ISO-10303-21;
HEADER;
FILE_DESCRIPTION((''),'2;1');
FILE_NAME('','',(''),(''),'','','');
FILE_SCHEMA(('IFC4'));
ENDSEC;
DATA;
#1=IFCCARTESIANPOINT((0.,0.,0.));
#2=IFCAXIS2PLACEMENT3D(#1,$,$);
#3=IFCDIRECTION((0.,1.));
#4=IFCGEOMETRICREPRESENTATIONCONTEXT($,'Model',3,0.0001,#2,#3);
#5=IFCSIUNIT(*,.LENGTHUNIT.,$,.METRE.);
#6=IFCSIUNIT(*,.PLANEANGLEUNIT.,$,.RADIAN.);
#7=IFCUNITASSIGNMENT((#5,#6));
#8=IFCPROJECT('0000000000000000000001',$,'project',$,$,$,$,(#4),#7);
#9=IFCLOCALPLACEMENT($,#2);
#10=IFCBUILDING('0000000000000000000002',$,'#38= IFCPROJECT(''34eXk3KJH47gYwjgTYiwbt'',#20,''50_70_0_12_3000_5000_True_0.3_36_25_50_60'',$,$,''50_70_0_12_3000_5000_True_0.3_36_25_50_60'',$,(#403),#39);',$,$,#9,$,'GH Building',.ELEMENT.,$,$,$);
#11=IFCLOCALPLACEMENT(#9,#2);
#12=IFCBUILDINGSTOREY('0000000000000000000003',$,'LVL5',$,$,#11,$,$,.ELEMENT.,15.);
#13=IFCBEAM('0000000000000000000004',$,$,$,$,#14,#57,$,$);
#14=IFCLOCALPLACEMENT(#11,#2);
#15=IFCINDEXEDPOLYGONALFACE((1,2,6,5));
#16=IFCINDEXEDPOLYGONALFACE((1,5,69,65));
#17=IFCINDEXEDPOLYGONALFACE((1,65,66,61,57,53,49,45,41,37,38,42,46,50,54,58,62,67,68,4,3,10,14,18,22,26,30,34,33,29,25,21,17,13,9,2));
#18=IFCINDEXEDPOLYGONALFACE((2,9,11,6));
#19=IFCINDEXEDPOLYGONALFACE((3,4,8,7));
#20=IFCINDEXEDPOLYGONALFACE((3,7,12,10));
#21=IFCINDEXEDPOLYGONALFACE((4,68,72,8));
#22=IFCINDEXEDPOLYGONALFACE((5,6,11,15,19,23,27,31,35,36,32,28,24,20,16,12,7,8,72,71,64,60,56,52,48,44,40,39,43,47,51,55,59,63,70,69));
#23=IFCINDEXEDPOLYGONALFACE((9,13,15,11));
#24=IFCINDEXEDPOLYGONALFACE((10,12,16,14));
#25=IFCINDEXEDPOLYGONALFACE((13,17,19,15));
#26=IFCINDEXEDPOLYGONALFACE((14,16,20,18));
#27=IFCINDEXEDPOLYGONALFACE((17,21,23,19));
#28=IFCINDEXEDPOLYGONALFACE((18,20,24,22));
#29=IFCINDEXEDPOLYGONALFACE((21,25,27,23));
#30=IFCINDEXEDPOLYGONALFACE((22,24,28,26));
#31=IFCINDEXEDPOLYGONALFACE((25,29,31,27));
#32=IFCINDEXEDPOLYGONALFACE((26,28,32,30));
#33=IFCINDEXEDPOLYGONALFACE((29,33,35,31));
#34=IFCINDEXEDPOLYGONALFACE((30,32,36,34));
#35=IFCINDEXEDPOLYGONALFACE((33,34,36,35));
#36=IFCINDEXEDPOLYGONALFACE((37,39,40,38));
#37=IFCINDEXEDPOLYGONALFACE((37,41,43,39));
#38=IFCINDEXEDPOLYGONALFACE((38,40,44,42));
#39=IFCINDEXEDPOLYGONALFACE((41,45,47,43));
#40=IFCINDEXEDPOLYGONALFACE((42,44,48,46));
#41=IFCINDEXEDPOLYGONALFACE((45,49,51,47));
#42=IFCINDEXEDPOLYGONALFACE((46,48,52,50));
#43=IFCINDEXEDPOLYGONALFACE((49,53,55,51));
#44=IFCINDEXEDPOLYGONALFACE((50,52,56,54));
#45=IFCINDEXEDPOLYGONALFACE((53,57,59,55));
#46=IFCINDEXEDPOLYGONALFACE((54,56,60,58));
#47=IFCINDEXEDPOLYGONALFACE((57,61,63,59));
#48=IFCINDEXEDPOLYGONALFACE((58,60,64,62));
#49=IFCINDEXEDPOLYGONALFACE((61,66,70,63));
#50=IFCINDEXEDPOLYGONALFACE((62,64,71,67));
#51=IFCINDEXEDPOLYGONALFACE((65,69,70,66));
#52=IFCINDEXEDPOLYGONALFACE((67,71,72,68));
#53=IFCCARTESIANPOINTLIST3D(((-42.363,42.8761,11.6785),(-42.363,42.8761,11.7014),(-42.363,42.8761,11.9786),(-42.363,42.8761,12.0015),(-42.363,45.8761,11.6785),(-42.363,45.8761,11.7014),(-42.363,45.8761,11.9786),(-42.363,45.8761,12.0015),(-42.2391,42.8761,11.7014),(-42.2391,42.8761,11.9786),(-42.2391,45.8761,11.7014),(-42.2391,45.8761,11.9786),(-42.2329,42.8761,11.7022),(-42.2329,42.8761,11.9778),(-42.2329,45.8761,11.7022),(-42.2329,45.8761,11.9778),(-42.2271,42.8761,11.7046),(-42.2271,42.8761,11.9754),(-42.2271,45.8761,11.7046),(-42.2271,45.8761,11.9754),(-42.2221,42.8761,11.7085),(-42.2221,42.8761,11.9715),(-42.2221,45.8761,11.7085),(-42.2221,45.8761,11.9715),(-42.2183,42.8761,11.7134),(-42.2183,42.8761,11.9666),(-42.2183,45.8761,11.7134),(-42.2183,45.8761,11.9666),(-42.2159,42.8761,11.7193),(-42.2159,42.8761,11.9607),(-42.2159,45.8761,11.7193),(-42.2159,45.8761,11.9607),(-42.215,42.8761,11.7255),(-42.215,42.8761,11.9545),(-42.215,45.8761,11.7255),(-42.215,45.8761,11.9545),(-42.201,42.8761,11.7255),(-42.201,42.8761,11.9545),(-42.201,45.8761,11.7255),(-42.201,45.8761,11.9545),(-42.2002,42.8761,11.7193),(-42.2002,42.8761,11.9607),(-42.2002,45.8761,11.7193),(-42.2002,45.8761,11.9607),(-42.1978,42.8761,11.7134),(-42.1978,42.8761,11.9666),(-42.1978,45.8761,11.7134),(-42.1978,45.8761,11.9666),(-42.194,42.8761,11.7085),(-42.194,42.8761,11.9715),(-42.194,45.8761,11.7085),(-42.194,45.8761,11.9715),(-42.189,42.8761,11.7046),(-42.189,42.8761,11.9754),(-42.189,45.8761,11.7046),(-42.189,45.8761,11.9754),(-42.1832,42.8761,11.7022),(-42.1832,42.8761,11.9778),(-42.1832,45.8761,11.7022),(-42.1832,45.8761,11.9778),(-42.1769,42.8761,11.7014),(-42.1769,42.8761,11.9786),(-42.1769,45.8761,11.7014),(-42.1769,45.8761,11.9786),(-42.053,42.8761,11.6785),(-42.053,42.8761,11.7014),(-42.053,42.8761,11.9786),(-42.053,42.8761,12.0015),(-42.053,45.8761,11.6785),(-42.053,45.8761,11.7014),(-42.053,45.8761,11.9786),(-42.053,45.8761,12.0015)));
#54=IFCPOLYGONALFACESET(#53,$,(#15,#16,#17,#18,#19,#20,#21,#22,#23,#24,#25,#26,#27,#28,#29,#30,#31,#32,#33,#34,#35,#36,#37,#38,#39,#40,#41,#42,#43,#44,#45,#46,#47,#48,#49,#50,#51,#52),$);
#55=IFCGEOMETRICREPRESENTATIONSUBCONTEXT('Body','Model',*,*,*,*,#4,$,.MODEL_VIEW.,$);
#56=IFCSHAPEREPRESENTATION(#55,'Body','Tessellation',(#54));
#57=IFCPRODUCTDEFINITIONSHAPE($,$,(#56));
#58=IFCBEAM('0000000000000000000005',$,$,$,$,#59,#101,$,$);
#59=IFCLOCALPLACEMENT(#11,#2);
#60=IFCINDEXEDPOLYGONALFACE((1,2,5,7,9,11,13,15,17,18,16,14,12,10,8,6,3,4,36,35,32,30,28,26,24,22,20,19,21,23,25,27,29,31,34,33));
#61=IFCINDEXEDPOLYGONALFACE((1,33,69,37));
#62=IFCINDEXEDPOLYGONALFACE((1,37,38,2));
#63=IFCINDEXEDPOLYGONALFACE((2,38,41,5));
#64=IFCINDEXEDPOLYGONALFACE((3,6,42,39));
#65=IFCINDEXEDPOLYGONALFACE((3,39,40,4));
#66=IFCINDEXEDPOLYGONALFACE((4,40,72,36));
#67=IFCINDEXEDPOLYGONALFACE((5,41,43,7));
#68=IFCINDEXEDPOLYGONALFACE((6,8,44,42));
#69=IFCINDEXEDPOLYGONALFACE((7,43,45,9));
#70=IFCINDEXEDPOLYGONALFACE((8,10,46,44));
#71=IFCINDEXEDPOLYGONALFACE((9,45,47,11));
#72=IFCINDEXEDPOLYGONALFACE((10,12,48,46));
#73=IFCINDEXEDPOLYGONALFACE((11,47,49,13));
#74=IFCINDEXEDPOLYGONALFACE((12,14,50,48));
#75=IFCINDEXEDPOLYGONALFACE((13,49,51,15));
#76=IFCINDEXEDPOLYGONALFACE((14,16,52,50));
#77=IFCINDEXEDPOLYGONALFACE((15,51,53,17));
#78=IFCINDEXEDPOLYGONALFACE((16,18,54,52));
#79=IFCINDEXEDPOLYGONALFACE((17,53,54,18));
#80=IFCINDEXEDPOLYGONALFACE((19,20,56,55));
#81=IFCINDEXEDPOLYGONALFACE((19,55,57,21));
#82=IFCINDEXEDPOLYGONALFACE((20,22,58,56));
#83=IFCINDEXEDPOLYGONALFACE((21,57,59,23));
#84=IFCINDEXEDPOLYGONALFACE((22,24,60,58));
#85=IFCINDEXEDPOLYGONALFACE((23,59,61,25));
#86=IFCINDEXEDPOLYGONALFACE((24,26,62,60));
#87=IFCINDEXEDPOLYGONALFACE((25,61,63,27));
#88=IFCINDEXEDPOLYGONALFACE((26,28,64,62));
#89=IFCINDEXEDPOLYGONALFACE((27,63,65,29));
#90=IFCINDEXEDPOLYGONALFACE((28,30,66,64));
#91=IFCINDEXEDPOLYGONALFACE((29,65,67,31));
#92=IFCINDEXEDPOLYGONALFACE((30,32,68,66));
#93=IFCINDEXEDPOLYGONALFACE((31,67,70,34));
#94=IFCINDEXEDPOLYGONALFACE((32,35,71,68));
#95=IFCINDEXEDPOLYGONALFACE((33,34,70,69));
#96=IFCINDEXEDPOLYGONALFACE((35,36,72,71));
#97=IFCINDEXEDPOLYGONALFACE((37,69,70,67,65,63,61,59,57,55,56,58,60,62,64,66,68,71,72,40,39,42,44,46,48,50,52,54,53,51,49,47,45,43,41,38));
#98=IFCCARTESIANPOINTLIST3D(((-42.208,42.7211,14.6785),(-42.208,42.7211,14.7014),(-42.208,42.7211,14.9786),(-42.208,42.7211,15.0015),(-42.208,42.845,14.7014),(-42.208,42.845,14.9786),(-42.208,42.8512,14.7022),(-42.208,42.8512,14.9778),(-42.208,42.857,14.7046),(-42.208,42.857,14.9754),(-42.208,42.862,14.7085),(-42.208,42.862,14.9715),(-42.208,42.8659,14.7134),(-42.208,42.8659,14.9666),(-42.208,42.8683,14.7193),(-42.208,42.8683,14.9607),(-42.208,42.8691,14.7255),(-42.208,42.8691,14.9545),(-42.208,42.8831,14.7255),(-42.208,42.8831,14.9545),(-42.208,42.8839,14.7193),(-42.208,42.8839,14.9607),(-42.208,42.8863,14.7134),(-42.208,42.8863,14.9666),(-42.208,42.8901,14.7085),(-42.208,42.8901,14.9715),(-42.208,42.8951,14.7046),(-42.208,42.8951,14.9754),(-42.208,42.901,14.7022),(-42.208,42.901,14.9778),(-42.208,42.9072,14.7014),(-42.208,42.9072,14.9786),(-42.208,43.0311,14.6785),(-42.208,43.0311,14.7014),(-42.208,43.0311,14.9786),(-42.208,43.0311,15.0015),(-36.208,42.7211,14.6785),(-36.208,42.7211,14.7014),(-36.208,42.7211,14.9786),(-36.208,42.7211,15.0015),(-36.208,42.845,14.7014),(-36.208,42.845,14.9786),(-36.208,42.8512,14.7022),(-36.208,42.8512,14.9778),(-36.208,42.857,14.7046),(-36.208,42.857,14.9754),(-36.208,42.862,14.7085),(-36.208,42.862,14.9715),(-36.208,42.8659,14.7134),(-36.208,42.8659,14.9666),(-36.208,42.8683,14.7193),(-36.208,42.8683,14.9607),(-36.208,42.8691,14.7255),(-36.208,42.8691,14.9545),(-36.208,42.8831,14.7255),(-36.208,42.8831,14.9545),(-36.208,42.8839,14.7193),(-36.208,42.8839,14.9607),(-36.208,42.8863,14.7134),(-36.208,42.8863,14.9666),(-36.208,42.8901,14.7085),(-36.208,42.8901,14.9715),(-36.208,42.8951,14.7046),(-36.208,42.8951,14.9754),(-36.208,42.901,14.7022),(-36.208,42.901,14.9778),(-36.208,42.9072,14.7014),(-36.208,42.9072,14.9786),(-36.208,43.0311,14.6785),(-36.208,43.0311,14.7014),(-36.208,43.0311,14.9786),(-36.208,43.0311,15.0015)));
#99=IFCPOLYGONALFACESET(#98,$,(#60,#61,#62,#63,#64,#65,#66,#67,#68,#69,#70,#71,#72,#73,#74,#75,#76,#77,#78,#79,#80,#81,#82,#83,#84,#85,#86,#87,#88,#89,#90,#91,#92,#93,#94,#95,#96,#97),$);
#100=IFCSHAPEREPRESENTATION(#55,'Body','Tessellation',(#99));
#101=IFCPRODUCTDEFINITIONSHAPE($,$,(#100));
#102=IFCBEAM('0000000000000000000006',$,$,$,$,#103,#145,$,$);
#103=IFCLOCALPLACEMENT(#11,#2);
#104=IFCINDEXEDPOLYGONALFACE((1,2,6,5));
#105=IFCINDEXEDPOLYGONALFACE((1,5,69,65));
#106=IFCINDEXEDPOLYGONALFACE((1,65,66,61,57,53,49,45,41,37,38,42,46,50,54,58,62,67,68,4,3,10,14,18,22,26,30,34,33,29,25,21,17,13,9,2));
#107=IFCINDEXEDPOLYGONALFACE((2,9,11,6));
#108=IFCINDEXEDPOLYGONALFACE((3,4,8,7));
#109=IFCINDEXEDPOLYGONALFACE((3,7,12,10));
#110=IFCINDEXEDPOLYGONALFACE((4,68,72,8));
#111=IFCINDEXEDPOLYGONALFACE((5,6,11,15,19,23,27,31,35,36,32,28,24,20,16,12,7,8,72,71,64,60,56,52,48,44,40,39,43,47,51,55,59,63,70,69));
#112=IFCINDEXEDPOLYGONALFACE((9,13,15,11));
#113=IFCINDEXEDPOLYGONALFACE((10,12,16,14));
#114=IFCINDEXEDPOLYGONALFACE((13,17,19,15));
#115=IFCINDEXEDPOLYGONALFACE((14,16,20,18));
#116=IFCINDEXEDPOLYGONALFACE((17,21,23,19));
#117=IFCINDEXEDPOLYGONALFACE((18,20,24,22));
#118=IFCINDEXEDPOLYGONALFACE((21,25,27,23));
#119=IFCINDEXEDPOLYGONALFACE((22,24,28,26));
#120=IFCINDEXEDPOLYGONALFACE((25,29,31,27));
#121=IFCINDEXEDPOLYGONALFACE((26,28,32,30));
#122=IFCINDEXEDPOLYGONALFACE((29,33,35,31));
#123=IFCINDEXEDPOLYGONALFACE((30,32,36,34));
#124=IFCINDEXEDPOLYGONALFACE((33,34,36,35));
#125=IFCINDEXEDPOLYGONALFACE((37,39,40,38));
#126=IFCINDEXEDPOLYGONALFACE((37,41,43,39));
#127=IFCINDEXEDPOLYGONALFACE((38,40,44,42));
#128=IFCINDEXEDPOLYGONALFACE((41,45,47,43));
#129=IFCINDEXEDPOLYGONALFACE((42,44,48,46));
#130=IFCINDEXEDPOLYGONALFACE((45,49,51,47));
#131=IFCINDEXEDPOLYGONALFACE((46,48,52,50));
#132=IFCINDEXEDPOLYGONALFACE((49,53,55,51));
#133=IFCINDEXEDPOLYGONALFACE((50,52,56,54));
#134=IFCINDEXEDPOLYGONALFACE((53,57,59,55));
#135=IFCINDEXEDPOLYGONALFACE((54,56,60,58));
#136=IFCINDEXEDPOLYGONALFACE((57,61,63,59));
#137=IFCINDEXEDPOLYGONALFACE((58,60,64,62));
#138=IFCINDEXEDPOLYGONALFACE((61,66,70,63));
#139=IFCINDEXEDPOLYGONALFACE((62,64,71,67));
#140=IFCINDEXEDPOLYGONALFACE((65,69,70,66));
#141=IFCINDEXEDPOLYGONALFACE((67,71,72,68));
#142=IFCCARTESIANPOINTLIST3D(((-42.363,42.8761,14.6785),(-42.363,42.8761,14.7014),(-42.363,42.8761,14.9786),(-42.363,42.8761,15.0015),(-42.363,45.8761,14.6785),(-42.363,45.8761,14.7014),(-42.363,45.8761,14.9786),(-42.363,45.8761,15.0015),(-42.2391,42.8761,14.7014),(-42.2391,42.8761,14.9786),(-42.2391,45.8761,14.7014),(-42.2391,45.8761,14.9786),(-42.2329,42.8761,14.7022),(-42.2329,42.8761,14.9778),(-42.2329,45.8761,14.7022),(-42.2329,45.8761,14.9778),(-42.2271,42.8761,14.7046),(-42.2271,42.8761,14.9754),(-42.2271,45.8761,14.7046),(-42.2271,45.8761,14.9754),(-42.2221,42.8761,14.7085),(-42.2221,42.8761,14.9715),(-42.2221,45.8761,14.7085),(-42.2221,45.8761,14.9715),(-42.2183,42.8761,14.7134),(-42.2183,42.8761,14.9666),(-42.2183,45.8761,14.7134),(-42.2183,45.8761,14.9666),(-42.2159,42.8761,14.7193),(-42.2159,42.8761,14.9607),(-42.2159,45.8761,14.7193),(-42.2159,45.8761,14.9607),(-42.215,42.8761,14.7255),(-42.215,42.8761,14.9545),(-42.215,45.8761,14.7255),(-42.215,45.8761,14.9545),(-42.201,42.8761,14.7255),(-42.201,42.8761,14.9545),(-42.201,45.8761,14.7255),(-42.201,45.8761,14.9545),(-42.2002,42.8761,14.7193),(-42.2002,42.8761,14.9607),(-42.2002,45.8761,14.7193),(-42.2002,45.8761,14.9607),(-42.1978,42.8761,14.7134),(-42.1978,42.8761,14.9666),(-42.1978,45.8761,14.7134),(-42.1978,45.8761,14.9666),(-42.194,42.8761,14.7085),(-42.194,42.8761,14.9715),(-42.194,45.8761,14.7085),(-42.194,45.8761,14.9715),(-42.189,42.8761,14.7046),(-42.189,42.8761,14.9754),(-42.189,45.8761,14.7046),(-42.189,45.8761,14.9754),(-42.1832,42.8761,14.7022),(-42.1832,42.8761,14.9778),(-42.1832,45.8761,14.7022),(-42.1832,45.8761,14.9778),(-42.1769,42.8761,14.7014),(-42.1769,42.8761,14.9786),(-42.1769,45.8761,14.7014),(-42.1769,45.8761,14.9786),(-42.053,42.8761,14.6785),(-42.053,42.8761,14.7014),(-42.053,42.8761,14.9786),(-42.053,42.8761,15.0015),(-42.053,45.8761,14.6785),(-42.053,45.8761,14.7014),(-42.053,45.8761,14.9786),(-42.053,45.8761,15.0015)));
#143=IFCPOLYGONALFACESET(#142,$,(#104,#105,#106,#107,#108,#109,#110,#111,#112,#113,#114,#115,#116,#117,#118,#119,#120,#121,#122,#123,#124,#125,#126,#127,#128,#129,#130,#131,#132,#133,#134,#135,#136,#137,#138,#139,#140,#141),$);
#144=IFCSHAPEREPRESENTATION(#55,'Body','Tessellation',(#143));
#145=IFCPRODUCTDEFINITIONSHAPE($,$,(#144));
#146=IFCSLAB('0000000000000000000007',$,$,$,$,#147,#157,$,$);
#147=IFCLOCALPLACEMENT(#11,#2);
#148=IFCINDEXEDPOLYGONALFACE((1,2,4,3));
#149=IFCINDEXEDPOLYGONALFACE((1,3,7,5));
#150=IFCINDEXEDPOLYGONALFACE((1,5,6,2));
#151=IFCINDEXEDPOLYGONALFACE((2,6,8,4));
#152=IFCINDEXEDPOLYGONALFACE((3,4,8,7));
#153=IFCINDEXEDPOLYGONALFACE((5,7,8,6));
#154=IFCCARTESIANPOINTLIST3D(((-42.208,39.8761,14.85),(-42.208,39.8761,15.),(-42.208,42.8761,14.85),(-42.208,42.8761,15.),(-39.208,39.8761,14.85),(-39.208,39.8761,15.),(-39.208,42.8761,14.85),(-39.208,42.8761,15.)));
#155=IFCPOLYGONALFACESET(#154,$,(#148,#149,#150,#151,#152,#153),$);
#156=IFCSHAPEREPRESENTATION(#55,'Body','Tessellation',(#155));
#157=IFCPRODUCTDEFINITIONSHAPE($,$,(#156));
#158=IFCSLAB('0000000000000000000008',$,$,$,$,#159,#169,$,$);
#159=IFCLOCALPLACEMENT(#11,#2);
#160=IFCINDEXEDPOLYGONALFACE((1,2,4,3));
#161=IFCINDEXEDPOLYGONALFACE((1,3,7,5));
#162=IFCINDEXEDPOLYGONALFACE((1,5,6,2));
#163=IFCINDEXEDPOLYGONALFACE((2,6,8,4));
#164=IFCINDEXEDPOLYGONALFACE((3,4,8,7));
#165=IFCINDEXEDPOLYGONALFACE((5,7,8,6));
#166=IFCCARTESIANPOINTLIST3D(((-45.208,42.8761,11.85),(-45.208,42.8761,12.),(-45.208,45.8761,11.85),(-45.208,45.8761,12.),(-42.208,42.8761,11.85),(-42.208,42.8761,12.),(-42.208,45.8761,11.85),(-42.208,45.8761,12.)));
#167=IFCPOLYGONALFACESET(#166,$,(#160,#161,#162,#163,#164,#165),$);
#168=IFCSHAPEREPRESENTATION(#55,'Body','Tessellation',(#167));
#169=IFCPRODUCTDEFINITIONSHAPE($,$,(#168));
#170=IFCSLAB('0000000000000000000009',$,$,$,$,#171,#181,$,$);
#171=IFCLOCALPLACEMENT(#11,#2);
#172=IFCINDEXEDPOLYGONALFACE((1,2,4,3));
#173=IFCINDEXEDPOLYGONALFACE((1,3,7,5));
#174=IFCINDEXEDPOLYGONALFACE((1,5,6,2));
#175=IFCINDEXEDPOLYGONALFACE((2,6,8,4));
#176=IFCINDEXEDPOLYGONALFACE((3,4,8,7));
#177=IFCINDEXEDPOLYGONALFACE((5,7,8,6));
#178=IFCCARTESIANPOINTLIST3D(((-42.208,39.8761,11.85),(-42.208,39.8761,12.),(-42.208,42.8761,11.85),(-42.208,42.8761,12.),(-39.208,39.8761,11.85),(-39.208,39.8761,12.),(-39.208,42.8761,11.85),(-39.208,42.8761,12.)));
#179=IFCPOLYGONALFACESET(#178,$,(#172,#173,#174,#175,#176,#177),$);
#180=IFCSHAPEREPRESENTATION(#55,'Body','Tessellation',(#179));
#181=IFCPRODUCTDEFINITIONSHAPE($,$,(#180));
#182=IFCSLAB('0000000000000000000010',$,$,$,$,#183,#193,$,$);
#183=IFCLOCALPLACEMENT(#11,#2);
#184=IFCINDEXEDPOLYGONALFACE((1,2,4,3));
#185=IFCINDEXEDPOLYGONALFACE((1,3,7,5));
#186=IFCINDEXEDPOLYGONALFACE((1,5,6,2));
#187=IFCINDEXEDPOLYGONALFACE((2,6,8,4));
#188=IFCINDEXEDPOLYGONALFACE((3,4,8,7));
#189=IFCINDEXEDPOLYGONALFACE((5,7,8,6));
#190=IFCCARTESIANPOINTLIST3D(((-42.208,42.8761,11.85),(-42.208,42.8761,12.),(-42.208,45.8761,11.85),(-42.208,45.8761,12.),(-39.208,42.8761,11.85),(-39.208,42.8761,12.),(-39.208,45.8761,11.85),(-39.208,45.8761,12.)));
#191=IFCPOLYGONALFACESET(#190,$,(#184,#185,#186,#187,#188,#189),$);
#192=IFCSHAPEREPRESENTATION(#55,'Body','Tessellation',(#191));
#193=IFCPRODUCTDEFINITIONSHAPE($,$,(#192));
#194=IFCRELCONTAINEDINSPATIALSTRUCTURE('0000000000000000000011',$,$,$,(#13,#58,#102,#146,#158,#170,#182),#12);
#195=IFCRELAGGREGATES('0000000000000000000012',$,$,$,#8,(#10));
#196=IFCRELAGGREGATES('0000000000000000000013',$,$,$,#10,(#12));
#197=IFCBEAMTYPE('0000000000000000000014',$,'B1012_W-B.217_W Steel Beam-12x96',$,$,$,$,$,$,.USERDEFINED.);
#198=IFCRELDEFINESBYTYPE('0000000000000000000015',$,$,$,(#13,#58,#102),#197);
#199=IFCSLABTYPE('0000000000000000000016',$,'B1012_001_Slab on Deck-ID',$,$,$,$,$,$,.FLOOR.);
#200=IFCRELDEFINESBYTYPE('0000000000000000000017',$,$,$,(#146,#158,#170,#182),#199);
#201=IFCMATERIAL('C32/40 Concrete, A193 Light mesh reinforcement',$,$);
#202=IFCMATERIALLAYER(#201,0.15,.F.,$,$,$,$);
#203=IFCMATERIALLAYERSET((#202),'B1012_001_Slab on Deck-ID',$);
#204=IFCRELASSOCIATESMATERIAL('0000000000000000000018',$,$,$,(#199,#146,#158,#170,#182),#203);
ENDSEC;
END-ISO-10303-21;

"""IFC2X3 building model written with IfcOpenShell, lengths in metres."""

from ifc_helpers import new_model, si_unit, direction, frame, origin, origin_2d, place, context, subcontext, project, spatial, polyline, i_section, outline, extrude, material, layer, layer_set, layer_usage, type_object, element, save


model = new_model("IFC2X3")

# Units and contexts
model_context = context("Model", 3, precision=0.0001, world=origin(), true_north=direction((0.0, 1.0)))
body_context = subcontext(model_context, "Body", "Model", "MODEL_VIEW")
ifc_project = project(units=[si_unit("LENGTHUNIT", "METRE"), si_unit("PLANEANGLEUNIT", "RADIAN")], contexts=[model_context])

# Building, storey
building_placement = place(None, origin())
building = spatial("IfcBuilding", under=ifc_project, at=building_placement, Name="#38= IFCPROJECT('34eXk3KJH47gYwjgTYiwbt',#20,'50_70_0_12_3000_5000_True_0.3_36_25_50_60',$,$,'50_70_0_12_3000_5000_True_0.3_36_25_50_60',$,(#403),#39);", LongName="GH Building", CompositionType="ELEMENT")
storey_placement = place(building_placement, origin())
storey = spatial("IfcBuildingStorey", under=building, at=storey_placement, Name="LVL5", CompositionType="ELEMENT", Elevation=15.0)

# Beams
beam_type = type_object("IfcBeamType", Name="B1012_W-B.217_W Steel Beam-12x96", PredefinedType="USERDEFINED")
beam_1_placement = place(storey_placement, frame((-42.208, 42.8761, 11.84), z_axis=(0.0, 1.0, 0.0), x_axis=(-1.0, 0.0, 0.0)))
element("IfcBeam", 1, at=beam_1_placement, inside=storey, type_object=beam_type, context=body_context, shape_type="SweptSolid", body=[
    extrude(i_section(OverallWidth=0.31, OverallDepth=0.323, WebThickness=0.014, FlangeThickness=0.0229, FilletRadius=0.0241, at=origin_2d()), origin(), (0.0, 0.0, 1.0), 3.0),
])
beam_2_placement = place(storey_placement, frame((-42.208, 42.8761, 14.84), z_axis=(1.0, 0.0, 0.0), x_axis=(0.0, 1.0, 0.0)))
element("IfcBeam", 2, at=beam_2_placement, inside=storey, type_object=beam_type, context=body_context, shape_type="SweptSolid", body=[
    extrude(i_section(OverallWidth=0.31, OverallDepth=0.323, WebThickness=0.014, FlangeThickness=0.0229, FilletRadius=0.0241, at=origin_2d()), origin(), (0.0, 0.0, 1.0), 6.0),
])
beam_3_placement = place(storey_placement, frame((-42.208, 42.8761, 14.84), z_axis=(0.0, 1.0, 0.0), x_axis=(-1.0, 0.0, 0.0)))
element("IfcBeam", 3, at=beam_3_placement, inside=storey, type_object=beam_type, context=body_context, shape_type="SweptSolid", body=[
    extrude(i_section(OverallWidth=0.31, OverallDepth=0.323, WebThickness=0.014, FlangeThickness=0.0229, FilletRadius=0.0241, at=origin_2d()), origin(), (0.0, 0.0, 1.0), 3.0),
])

# Slabs
ifc_material_1 = material(Name="C32/40 Concrete, A193 Light mesh reinforcement")
ifc_layer_1 = layer(ifc_material_1, 0.15, ventilated=False)
ifc_layer_set_1 = layer_set([ifc_layer_1], Name="B1012_001_Slab on Deck-ID")
ifc_layer_usage_1 = layer_usage(ifc_layer_set_1, "AXIS3", "NEGATIVE", -0.15)
slab_type_1 = type_object("IfcSlabType", Name="B1012_001_Slab on Deck-ID", PredefinedType="FLOOR", material=ifc_layer_set_1)
slab_1_placement = place(storey_placement, frame((-40.708, 41.3761, 14.85)))
element("IfcSlab", 4, at=slab_1_placement, inside=storey, type_object=slab_type_1, material=ifc_layer_usage_1, context=body_context, shape_type="SweptSolid", body=[
    extrude(outline(polyline([(-1.5, -1.5), (-1.5, 1.5), (1.5, 1.5), (1.5, -1.5), (-1.5, -1.5)])), origin(), (0.0, 0.0, 1.0), 0.15),
])
ifc_layer_usage_2 = layer_usage(ifc_layer_set_1, "AXIS3", "NEGATIVE", -0.15)
slab_2_placement = place(storey_placement, frame((-43.708, 44.3761, 11.85)))
element("IfcSlab", 5, at=slab_2_placement, inside=storey, type_object=slab_type_1, material=ifc_layer_usage_2, context=body_context, shape_type="SweptSolid", body=[
    extrude(outline(polyline([(-1.5, 1.5), (1.5, 1.5), (1.5, -1.5), (-1.5, -1.5), (-1.5, 1.5)])), origin(), (0.0, 0.0, 1.0), 0.15),
])
ifc_layer_usage_3 = layer_usage(ifc_layer_set_1, "AXIS3", "NEGATIVE", -0.15)
slab_3_placement = place(storey_placement, frame((-40.708, 41.3761, 11.85)))
element("IfcSlab", 6, at=slab_3_placement, inside=storey, type_object=slab_type_1, material=ifc_layer_usage_3, context=body_context, shape_type="SweptSolid", body=[
    extrude(outline(polyline([(-1.5, -1.5), (-1.5, 1.5), (1.5, 1.5), (1.5, -1.5), (-1.5, -1.5)])), origin(), (0.0, 0.0, 1.0), 0.15),
])
ifc_layer_usage_4 = layer_usage(ifc_layer_set_1, "AXIS3", "NEGATIVE", -0.15)
slab_4_placement = place(storey_placement, frame((-40.708, 44.3761, 11.85)))
element("IfcSlab", 7, at=slab_4_placement, inside=storey, type_object=slab_type_1, material=ifc_layer_usage_4, context=body_context, shape_type="SweptSolid", body=[
    extrude(outline(polyline([(-1.5, 1.5), (1.5, 1.5), (1.5, -1.5), (-1.5, -1.5), (-1.5, 1.5)])), origin(), (0.0, 0.0, 1.0), 0.15),
])

save(model, "model.ifc")
